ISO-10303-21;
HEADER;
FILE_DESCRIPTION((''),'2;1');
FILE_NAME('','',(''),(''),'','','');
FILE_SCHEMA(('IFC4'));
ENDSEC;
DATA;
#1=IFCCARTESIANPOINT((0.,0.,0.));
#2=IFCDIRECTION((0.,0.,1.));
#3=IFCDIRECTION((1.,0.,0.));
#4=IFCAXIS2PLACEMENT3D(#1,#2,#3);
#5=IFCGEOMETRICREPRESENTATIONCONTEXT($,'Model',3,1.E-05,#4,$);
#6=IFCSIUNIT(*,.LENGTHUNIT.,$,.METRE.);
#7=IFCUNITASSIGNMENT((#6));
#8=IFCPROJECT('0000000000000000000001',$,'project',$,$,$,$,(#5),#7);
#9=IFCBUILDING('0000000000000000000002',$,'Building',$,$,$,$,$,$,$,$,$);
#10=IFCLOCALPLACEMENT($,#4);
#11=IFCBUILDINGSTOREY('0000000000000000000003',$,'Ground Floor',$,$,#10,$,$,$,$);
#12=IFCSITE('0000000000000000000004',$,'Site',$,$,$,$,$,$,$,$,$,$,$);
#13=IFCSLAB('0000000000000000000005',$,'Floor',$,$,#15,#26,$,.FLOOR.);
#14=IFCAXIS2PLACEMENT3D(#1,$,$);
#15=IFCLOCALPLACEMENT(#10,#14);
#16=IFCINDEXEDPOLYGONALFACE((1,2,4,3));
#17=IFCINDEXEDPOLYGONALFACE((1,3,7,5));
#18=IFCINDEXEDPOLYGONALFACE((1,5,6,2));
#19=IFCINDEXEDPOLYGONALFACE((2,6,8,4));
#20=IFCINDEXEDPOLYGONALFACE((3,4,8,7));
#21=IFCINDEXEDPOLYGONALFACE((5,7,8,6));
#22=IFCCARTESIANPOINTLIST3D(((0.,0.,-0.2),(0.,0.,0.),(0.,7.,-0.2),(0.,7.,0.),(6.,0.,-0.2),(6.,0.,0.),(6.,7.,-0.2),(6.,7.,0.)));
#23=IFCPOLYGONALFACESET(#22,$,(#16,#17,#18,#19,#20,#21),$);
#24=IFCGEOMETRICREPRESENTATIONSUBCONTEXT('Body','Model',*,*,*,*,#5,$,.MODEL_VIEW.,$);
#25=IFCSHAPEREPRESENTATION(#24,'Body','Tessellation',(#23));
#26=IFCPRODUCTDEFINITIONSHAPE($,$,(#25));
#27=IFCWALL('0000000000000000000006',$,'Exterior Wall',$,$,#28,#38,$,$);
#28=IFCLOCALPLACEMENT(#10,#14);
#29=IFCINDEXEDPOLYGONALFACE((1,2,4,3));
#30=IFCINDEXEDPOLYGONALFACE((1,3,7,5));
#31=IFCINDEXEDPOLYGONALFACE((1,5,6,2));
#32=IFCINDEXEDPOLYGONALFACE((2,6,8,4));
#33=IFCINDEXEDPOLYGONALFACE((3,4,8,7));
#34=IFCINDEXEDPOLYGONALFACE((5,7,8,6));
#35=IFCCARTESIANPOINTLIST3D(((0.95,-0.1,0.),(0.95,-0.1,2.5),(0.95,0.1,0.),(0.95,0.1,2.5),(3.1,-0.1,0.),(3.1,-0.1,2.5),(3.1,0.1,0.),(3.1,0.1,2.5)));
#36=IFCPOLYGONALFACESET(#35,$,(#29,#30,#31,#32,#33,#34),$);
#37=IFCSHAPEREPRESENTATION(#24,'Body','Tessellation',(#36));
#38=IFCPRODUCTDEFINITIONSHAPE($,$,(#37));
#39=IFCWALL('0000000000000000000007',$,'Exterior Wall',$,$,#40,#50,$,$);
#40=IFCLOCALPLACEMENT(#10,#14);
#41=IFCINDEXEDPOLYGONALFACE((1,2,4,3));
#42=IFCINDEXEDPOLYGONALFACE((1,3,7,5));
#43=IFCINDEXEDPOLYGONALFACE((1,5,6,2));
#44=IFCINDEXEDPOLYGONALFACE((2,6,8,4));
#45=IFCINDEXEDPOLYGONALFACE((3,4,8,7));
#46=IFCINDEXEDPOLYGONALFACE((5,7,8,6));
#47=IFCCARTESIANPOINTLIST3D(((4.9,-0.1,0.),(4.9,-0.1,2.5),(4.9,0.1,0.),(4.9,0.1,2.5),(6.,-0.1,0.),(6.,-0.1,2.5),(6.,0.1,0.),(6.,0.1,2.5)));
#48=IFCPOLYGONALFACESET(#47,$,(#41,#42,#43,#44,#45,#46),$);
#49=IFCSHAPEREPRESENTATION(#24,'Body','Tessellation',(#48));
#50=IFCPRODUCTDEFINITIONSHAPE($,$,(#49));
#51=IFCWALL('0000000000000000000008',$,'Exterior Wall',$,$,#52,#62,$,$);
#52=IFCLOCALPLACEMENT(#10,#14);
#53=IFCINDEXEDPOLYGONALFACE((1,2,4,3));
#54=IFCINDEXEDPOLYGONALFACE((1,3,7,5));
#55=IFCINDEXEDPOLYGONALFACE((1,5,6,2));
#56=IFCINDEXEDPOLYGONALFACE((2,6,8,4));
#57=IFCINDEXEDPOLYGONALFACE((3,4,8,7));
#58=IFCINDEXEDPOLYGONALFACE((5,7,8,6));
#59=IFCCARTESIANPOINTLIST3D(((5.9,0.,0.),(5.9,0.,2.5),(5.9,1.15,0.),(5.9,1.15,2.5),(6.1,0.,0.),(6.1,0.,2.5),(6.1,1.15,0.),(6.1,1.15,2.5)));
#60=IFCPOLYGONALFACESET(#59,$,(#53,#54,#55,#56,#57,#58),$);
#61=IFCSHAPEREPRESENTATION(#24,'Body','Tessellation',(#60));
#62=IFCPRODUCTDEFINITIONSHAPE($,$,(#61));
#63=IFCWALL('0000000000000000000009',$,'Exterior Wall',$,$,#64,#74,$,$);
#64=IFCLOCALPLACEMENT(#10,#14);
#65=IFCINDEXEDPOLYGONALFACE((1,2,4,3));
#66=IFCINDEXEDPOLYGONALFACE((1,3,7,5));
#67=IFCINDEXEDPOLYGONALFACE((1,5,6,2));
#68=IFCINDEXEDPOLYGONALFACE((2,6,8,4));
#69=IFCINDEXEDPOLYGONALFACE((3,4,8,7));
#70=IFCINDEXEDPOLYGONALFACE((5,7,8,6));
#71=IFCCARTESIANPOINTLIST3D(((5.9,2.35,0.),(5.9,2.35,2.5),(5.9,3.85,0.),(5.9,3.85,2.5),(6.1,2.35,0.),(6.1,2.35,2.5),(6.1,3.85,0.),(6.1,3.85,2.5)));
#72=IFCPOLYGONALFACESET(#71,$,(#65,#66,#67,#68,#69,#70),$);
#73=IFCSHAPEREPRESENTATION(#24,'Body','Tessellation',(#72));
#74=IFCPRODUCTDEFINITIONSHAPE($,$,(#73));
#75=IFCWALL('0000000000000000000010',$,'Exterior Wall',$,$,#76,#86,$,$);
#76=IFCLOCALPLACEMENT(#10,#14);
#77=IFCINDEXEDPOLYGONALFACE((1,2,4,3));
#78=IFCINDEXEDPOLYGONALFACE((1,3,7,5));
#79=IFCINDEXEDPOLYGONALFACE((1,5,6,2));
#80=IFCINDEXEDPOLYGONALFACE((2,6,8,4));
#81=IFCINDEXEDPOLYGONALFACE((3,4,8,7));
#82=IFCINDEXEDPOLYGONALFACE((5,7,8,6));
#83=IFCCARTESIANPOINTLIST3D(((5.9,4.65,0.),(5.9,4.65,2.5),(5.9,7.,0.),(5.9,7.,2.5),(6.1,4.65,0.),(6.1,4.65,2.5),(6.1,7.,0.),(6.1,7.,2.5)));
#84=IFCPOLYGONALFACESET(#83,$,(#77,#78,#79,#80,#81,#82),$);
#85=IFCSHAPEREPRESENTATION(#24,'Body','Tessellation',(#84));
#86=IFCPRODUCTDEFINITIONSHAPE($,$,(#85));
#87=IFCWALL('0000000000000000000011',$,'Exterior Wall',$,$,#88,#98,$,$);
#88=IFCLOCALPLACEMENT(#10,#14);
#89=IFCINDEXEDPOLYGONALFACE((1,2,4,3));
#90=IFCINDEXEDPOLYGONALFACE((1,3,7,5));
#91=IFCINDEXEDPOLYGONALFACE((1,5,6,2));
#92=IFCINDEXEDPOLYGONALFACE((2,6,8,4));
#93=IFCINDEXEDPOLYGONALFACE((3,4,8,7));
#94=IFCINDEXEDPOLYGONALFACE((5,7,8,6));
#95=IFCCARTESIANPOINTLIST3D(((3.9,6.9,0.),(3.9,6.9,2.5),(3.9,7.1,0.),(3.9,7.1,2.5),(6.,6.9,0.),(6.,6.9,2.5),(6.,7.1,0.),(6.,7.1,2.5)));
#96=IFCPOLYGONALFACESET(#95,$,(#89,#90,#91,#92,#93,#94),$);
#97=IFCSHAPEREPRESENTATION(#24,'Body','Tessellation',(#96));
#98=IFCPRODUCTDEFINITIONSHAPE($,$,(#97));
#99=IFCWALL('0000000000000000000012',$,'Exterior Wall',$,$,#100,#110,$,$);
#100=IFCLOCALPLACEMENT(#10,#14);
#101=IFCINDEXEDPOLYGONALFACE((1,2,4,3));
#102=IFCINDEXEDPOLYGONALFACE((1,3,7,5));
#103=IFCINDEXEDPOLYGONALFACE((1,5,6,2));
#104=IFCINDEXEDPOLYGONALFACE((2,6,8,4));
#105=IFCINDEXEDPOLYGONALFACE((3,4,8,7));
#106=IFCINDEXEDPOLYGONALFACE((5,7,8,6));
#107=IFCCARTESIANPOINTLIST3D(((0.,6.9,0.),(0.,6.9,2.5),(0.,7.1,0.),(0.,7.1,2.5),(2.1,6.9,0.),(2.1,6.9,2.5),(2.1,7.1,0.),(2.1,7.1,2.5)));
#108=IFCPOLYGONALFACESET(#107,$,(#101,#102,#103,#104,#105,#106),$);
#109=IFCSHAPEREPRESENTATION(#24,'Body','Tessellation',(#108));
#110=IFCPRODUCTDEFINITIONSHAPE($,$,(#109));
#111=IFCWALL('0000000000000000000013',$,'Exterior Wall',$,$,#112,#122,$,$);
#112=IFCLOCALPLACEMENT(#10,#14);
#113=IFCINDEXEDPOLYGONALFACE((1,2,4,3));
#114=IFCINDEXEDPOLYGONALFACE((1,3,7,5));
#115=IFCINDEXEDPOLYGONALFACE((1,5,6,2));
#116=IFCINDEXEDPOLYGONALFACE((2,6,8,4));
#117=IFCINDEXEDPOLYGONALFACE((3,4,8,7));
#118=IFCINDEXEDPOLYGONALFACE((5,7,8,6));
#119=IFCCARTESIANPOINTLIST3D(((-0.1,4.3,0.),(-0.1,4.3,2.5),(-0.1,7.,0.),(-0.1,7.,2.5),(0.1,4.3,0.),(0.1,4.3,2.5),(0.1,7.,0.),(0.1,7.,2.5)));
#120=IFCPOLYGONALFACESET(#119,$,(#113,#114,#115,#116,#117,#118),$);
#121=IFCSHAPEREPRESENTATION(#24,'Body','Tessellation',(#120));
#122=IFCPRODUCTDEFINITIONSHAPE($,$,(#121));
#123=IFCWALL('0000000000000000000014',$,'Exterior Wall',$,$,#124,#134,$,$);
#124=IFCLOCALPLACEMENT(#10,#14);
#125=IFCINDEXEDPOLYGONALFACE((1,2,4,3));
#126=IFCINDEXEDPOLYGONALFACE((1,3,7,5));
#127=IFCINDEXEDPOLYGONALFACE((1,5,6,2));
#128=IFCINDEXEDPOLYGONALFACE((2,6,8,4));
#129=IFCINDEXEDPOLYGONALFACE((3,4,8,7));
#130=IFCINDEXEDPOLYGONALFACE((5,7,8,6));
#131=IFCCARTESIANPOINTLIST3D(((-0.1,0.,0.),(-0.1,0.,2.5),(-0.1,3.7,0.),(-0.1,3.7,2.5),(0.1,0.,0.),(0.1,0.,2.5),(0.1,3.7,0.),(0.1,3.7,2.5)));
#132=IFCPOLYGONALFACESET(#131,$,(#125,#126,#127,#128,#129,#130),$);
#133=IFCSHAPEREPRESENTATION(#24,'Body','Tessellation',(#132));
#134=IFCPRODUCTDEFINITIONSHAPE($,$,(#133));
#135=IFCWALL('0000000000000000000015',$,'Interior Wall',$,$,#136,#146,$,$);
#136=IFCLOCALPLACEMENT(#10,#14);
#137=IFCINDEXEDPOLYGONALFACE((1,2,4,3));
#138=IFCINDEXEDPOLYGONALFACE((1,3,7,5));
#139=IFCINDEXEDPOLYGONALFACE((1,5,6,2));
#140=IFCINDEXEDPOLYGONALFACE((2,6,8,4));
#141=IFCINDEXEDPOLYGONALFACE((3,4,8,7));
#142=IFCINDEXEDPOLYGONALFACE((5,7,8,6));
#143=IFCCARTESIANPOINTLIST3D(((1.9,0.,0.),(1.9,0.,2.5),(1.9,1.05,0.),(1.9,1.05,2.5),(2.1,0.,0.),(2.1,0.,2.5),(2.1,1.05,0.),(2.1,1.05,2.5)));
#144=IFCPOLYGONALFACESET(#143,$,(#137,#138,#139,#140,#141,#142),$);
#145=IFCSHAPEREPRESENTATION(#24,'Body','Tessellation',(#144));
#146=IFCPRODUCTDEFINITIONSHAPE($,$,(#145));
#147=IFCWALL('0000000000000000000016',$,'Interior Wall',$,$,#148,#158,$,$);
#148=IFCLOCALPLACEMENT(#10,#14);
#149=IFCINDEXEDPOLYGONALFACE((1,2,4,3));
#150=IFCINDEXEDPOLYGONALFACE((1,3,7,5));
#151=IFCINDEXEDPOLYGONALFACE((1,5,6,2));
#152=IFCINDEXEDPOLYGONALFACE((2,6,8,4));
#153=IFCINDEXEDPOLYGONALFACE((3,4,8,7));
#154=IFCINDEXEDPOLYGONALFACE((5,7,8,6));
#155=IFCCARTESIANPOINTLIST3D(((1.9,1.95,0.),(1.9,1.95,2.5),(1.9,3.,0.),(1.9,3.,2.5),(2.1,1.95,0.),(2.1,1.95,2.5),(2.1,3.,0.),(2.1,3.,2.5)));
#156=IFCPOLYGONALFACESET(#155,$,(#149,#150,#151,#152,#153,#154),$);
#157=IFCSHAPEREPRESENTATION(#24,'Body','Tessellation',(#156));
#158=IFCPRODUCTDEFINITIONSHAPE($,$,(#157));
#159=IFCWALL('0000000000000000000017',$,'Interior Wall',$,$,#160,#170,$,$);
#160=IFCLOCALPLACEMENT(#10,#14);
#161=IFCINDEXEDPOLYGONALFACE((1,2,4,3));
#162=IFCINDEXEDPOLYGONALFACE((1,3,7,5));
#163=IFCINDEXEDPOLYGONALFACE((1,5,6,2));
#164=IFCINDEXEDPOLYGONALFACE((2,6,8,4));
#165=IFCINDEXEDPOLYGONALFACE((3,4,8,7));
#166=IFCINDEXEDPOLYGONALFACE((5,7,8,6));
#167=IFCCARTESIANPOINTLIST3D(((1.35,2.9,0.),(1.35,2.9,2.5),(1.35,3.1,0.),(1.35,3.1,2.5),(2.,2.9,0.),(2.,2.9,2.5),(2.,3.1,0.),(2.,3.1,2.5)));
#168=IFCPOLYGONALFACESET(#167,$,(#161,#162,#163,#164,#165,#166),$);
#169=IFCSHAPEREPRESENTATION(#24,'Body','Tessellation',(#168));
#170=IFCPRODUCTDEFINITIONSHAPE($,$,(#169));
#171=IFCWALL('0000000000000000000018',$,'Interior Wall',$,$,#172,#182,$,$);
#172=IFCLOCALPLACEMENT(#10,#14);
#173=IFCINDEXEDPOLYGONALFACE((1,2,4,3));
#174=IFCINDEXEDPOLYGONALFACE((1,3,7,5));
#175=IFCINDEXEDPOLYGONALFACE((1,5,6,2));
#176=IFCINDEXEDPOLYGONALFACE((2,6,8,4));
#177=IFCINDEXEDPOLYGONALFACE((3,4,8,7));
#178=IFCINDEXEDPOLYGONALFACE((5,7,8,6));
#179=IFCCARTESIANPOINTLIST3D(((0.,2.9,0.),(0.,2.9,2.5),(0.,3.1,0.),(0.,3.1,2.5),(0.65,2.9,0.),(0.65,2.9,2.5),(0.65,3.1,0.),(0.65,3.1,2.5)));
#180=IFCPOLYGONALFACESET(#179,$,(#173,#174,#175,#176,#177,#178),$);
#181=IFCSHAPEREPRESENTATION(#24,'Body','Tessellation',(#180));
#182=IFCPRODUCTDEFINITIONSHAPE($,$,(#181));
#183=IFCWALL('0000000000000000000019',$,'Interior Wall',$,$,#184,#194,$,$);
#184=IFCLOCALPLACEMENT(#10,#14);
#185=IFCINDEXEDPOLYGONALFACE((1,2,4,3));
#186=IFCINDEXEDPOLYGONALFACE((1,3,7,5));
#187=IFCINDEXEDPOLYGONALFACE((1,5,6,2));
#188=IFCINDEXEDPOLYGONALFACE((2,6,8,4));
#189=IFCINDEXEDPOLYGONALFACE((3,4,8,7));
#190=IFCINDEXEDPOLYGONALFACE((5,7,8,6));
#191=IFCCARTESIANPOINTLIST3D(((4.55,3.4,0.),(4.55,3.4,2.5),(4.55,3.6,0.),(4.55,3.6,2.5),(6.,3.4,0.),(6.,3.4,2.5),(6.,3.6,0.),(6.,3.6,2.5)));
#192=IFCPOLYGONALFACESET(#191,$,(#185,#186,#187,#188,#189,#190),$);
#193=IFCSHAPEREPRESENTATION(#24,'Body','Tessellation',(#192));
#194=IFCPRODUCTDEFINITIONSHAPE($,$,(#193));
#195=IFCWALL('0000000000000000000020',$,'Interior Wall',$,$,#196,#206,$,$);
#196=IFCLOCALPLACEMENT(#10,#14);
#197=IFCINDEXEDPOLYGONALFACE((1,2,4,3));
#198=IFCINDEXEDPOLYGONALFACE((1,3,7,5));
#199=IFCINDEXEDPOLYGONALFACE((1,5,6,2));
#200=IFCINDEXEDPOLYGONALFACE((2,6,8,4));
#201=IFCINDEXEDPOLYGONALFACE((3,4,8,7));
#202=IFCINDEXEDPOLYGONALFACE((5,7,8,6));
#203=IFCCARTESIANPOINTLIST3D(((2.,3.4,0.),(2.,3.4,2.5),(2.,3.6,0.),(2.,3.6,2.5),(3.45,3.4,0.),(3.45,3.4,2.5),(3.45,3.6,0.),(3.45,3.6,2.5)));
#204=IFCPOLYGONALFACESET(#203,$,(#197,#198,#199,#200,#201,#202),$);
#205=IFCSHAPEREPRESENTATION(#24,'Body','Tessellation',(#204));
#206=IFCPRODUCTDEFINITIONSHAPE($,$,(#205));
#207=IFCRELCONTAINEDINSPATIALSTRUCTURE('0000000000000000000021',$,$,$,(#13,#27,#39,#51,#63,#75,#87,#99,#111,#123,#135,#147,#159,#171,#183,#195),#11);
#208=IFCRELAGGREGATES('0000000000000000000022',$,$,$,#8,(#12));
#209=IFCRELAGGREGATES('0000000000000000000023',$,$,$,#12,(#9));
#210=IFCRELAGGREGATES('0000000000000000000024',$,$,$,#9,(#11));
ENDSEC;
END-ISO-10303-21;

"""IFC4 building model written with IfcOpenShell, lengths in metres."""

from ifc_helpers import new_model, si_unit, frame, origin_with_axes, place, context, subcontext, project, spatial, indexed_curve, outline, extrude, element, save


model = new_model("IFC4")

# Units and contexts
model_context = context("Model", 3, precision=1e-05, world=origin_with_axes())
body_context = subcontext(model_context, "Body", "Model", "MODEL_VIEW")
ifc_project = project(units=[si_unit("LENGTHUNIT", "METRE")], contexts=[model_context])

# Site, building, storey
site = spatial("IfcSite", under=ifc_project, Name="Site")
building = spatial("IfcBuilding", under=site, Name="Building")
storey_placement = place(None, origin_with_axes())
storey = spatial("IfcBuildingStorey", under=building, at=storey_placement, Name="Ground Floor")

# Slab
slab_placement = place(storey_placement, frame((0.0, 0.0, -0.2), z_axis=(0.0, 0.0, 1.0), x_axis=(1.0, 0.0, 0.0)))
element("IfcSlab", 1, at=slab_placement, inside=storey, Name="Floor", PredefinedType="FLOOR", context=body_context, shape_type="SweptSolid", body=[
    extrude(outline(indexed_curve([(0.0, 0.0), (6.0, 0.0), (6.0, 7.0), (0.0, 7.0)])), None, (0.0, 0.0, 1.0), 0.2),
])

# Walls
wall_1_placement = place(storey_placement, frame((0.95, 0.0, 0.0), z_axis=(0.0, 0.0, 1.0), x_axis=(1.0, 0.0, 0.0)))
element("IfcWall", 2, at=wall_1_placement, inside=storey, Name="Exterior Wall", context=body_context, shape_type="SweptSolid", body=[
    extrude(outline(indexed_curve([(0.0, 0.0), (0.0, 0.2), (2.15, 0.2), (2.15, 0.0), (0.0, 0.0)], self_intersect=False)), frame((0.0, -0.1, 0.0), z_axis=(0.0, 0.0, 1.0), x_axis=(1.0, 0.0, 0.0)), (0.0, 0.0, 1.0), 2.5),
])
wall_2_placement = place(storey_placement, frame((4.9, 0.0, 0.0), z_axis=(0.0, 0.0, 1.0), x_axis=(1.0, 0.0, 0.0)))
element("IfcWall", 3, at=wall_2_placement, inside=storey, Name="Exterior Wall", context=body_context, shape_type="SweptSolid", body=[
    extrude(outline(indexed_curve([(0.0, 0.0), (0.0, 0.2), (1.1, 0.2), (1.1, 0.0), (0.0, 0.0)], self_intersect=False)), frame((0.0, -0.1, 0.0), z_axis=(0.0, 0.0, 1.0), x_axis=(1.0, 0.0, 0.0)), (0.0, 0.0, 1.0), 2.5),
])
wall_3_placement = place(storey_placement, frame((6.0, 0.0, 0.0), z_axis=(0.0, 0.0, 1.0), x_axis=(0.0, 1.0, 0.0)))
element("IfcWall", 4, at=wall_3_placement, inside=storey, Name="Exterior Wall", context=body_context, shape_type="SweptSolid", body=[
    extrude(outline(indexed_curve([(0.0, 0.0), (0.0, 0.2), (1.15, 0.2), (1.15, 0.0), (0.0, 0.0)], self_intersect=False)), frame((0.0, -0.1, 0.0), z_axis=(0.0, 0.0, 1.0), x_axis=(1.0, 0.0, 0.0)), (0.0, 0.0, 1.0), 2.5),
])
wall_4_placement = place(storey_placement, frame((6.0, 2.35, 0.0), z_axis=(0.0, 0.0, 1.0), x_axis=(0.0, 1.0, 0.0)))
element("IfcWall", 5, at=wall_4_placement, inside=storey, Name="Exterior Wall", context=body_context, shape_type="SweptSolid", body=[
    extrude(outline(indexed_curve([(0.0, 0.0), (0.0, 0.2), (1.5, 0.2), (1.5, 0.0), (0.0, 0.0)], self_intersect=False)), frame((0.0, -0.1, 0.0), z_axis=(0.0, 0.0, 1.0), x_axis=(1.0, 0.0, 0.0)), (0.0, 0.0, 1.0), 2.5),
])
wall_5_placement = place(storey_placement, frame((6.0, 4.65, 0.0), z_axis=(0.0, 0.0, 1.0), x_axis=(0.0, 1.0, 0.0)))
element("IfcWall", 6, at=wall_5_placement, inside=storey, Name="Exterior Wall", context=body_context, shape_type="SweptSolid", body=[
    extrude(outline(indexed_curve([(0.0, 0.0), (0.0, 0.2), (2.35, 0.2), (2.35, 0.0), (0.0, 0.0)], self_intersect=False)), frame((0.0, -0.1, 0.0), z_axis=(0.0, 0.0, 1.0), x_axis=(1.0, 0.0, 0.0)), (0.0, 0.0, 1.0), 2.5),
])
for number, where, z_axis, x_axis, name in (
    (7, (6.0, 7.0, 0.0), (0.0, 0.0, 1.0), (-1.0, 0.0, 0.0), "Exterior Wall"),
    (8, (2.1, 7.0, 0.0), (0.0, 0.0, 1.0), (-1.0, 0.0, 0.0), "Exterior Wall"),
):
    element("IfcWall", number, at=place(storey_placement, frame(where, z_axis=z_axis, x_axis=x_axis)), inside=storey, Name=name, context=body_context, shape_type="SweptSolid", body=[
        extrude(outline(indexed_curve([(0.0, 0.0), (0.0, 0.2), (2.1, 0.2), (2.1, 0.0), (0.0, 0.0)], self_intersect=False)), frame((0.0, -0.1, 0.0), z_axis=(0.0, 0.0, 1.0), x_axis=(1.0, 0.0, 0.0)), (0.0, 0.0, 1.0), 2.5),
    ])
wall_6_placement = place(storey_placement, frame((0.0, 7.0, 0.0), z_axis=(0.0, 0.0, 1.0), x_axis=(0.0, -1.0, 0.0)))
element("IfcWall", 9, at=wall_6_placement, inside=storey, Name="Exterior Wall", context=body_context, shape_type="SweptSolid", body=[
    extrude(outline(indexed_curve([(0.0, 0.0), (0.0, 0.2), (2.7, 0.2), (2.7, 0.0), (0.0, 0.0)], self_intersect=False)), frame((0.0, -0.1, 0.0), z_axis=(0.0, 0.0, 1.0), x_axis=(1.0, 0.0, 0.0)), (0.0, 0.0, 1.0), 2.5),
])
wall_7_placement = place(storey_placement, frame((0.0, 3.7, 0.0), z_axis=(0.0, 0.0, 1.0), x_axis=(0.0, -1.0, 0.0)))
element("IfcWall", 10, at=wall_7_placement, inside=storey, Name="Exterior Wall", context=body_context, shape_type="SweptSolid", body=[
    extrude(outline(indexed_curve([(0.0, 0.0), (0.0, 0.2), (3.7, 0.2), (3.7, 0.0), (0.0, 0.0)], self_intersect=False)), frame((0.0, -0.1, 0.0), z_axis=(0.0, 0.0, 1.0), x_axis=(1.0, 0.0, 0.0)), (0.0, 0.0, 1.0), 2.5),
])
for number, where, z_axis, x_axis, name in (
    (11, (2.0, 0.0, 0.0), (0.0, 0.0, 1.0), (0.0, 1.0, 0.0), "Interior Wall"),
    (12, (2.0, 1.95, 0.0), (0.0, 0.0, 1.0), (0.0, 1.0, 0.0), "Interior Wall"),
):
    element("IfcWall", number, at=place(storey_placement, frame(where, z_axis=z_axis, x_axis=x_axis)), inside=storey, Name=name, context=body_context, shape_type="SweptSolid", body=[
        extrude(outline(indexed_curve([(0.0, 0.0), (0.0, 0.2), (1.05, 0.2), (1.05, 0.0), (0.0, 0.0)], self_intersect=False)), frame((0.0, -0.1, 0.0), z_axis=(0.0, 0.0, 1.0), x_axis=(1.0, 0.0, 0.0)), (0.0, 0.0, 1.0), 2.5),
    ])
for number, where, z_axis, x_axis, name in (
    (13, (2.0, 3.0, 0.0), (0.0, 0.0, 1.0), (-1.0, 0.0, 0.0), "Interior Wall"),
    (14, (0.65, 3.0, 0.0), (0.0, 0.0, 1.0), (-1.0, 0.0, 0.0), "Interior Wall"),
):
    element("IfcWall", number, at=place(storey_placement, frame(where, z_axis=z_axis, x_axis=x_axis)), inside=storey, Name=name, context=body_context, shape_type="SweptSolid", body=[
        extrude(outline(indexed_curve([(0.0, 0.0), (0.0, 0.2), (0.65, 0.2), (0.65, 0.0), (0.0, 0.0)], self_intersect=False)), frame((0.0, -0.1, 0.0), z_axis=(0.0, 0.0, 1.0), x_axis=(1.0, 0.0, 0.0)), (0.0, 0.0, 1.0), 2.5),
    ])
for number, where, z_axis, x_axis, name in (
    (15, (6.0, 3.5, 0.0), (0.0, 0.0, 1.0), (-1.0, 0.0, 0.0), "Interior Wall"),
    (16, (3.45, 3.5, 0.0), (0.0, 0.0, 1.0), (-1.0, 0.0, 0.0), "Interior Wall"),
):
    element("IfcWall", number, at=place(storey_placement, frame(where, z_axis=z_axis, x_axis=x_axis)), inside=storey, Name=name, context=body_context, shape_type="SweptSolid", body=[
        extrude(outline(indexed_curve([(0.0, 0.0), (0.0, 0.2), (1.45, 0.2), (1.45, 0.0), (0.0, 0.0)], self_intersect=False)), frame((0.0, -0.1, 0.0), z_axis=(0.0, 0.0, 1.0), x_axis=(1.0, 0.0, 0.0)), (0.0, 0.0, 1.0), 2.5),
    ])

save(model, "model.ifc")
